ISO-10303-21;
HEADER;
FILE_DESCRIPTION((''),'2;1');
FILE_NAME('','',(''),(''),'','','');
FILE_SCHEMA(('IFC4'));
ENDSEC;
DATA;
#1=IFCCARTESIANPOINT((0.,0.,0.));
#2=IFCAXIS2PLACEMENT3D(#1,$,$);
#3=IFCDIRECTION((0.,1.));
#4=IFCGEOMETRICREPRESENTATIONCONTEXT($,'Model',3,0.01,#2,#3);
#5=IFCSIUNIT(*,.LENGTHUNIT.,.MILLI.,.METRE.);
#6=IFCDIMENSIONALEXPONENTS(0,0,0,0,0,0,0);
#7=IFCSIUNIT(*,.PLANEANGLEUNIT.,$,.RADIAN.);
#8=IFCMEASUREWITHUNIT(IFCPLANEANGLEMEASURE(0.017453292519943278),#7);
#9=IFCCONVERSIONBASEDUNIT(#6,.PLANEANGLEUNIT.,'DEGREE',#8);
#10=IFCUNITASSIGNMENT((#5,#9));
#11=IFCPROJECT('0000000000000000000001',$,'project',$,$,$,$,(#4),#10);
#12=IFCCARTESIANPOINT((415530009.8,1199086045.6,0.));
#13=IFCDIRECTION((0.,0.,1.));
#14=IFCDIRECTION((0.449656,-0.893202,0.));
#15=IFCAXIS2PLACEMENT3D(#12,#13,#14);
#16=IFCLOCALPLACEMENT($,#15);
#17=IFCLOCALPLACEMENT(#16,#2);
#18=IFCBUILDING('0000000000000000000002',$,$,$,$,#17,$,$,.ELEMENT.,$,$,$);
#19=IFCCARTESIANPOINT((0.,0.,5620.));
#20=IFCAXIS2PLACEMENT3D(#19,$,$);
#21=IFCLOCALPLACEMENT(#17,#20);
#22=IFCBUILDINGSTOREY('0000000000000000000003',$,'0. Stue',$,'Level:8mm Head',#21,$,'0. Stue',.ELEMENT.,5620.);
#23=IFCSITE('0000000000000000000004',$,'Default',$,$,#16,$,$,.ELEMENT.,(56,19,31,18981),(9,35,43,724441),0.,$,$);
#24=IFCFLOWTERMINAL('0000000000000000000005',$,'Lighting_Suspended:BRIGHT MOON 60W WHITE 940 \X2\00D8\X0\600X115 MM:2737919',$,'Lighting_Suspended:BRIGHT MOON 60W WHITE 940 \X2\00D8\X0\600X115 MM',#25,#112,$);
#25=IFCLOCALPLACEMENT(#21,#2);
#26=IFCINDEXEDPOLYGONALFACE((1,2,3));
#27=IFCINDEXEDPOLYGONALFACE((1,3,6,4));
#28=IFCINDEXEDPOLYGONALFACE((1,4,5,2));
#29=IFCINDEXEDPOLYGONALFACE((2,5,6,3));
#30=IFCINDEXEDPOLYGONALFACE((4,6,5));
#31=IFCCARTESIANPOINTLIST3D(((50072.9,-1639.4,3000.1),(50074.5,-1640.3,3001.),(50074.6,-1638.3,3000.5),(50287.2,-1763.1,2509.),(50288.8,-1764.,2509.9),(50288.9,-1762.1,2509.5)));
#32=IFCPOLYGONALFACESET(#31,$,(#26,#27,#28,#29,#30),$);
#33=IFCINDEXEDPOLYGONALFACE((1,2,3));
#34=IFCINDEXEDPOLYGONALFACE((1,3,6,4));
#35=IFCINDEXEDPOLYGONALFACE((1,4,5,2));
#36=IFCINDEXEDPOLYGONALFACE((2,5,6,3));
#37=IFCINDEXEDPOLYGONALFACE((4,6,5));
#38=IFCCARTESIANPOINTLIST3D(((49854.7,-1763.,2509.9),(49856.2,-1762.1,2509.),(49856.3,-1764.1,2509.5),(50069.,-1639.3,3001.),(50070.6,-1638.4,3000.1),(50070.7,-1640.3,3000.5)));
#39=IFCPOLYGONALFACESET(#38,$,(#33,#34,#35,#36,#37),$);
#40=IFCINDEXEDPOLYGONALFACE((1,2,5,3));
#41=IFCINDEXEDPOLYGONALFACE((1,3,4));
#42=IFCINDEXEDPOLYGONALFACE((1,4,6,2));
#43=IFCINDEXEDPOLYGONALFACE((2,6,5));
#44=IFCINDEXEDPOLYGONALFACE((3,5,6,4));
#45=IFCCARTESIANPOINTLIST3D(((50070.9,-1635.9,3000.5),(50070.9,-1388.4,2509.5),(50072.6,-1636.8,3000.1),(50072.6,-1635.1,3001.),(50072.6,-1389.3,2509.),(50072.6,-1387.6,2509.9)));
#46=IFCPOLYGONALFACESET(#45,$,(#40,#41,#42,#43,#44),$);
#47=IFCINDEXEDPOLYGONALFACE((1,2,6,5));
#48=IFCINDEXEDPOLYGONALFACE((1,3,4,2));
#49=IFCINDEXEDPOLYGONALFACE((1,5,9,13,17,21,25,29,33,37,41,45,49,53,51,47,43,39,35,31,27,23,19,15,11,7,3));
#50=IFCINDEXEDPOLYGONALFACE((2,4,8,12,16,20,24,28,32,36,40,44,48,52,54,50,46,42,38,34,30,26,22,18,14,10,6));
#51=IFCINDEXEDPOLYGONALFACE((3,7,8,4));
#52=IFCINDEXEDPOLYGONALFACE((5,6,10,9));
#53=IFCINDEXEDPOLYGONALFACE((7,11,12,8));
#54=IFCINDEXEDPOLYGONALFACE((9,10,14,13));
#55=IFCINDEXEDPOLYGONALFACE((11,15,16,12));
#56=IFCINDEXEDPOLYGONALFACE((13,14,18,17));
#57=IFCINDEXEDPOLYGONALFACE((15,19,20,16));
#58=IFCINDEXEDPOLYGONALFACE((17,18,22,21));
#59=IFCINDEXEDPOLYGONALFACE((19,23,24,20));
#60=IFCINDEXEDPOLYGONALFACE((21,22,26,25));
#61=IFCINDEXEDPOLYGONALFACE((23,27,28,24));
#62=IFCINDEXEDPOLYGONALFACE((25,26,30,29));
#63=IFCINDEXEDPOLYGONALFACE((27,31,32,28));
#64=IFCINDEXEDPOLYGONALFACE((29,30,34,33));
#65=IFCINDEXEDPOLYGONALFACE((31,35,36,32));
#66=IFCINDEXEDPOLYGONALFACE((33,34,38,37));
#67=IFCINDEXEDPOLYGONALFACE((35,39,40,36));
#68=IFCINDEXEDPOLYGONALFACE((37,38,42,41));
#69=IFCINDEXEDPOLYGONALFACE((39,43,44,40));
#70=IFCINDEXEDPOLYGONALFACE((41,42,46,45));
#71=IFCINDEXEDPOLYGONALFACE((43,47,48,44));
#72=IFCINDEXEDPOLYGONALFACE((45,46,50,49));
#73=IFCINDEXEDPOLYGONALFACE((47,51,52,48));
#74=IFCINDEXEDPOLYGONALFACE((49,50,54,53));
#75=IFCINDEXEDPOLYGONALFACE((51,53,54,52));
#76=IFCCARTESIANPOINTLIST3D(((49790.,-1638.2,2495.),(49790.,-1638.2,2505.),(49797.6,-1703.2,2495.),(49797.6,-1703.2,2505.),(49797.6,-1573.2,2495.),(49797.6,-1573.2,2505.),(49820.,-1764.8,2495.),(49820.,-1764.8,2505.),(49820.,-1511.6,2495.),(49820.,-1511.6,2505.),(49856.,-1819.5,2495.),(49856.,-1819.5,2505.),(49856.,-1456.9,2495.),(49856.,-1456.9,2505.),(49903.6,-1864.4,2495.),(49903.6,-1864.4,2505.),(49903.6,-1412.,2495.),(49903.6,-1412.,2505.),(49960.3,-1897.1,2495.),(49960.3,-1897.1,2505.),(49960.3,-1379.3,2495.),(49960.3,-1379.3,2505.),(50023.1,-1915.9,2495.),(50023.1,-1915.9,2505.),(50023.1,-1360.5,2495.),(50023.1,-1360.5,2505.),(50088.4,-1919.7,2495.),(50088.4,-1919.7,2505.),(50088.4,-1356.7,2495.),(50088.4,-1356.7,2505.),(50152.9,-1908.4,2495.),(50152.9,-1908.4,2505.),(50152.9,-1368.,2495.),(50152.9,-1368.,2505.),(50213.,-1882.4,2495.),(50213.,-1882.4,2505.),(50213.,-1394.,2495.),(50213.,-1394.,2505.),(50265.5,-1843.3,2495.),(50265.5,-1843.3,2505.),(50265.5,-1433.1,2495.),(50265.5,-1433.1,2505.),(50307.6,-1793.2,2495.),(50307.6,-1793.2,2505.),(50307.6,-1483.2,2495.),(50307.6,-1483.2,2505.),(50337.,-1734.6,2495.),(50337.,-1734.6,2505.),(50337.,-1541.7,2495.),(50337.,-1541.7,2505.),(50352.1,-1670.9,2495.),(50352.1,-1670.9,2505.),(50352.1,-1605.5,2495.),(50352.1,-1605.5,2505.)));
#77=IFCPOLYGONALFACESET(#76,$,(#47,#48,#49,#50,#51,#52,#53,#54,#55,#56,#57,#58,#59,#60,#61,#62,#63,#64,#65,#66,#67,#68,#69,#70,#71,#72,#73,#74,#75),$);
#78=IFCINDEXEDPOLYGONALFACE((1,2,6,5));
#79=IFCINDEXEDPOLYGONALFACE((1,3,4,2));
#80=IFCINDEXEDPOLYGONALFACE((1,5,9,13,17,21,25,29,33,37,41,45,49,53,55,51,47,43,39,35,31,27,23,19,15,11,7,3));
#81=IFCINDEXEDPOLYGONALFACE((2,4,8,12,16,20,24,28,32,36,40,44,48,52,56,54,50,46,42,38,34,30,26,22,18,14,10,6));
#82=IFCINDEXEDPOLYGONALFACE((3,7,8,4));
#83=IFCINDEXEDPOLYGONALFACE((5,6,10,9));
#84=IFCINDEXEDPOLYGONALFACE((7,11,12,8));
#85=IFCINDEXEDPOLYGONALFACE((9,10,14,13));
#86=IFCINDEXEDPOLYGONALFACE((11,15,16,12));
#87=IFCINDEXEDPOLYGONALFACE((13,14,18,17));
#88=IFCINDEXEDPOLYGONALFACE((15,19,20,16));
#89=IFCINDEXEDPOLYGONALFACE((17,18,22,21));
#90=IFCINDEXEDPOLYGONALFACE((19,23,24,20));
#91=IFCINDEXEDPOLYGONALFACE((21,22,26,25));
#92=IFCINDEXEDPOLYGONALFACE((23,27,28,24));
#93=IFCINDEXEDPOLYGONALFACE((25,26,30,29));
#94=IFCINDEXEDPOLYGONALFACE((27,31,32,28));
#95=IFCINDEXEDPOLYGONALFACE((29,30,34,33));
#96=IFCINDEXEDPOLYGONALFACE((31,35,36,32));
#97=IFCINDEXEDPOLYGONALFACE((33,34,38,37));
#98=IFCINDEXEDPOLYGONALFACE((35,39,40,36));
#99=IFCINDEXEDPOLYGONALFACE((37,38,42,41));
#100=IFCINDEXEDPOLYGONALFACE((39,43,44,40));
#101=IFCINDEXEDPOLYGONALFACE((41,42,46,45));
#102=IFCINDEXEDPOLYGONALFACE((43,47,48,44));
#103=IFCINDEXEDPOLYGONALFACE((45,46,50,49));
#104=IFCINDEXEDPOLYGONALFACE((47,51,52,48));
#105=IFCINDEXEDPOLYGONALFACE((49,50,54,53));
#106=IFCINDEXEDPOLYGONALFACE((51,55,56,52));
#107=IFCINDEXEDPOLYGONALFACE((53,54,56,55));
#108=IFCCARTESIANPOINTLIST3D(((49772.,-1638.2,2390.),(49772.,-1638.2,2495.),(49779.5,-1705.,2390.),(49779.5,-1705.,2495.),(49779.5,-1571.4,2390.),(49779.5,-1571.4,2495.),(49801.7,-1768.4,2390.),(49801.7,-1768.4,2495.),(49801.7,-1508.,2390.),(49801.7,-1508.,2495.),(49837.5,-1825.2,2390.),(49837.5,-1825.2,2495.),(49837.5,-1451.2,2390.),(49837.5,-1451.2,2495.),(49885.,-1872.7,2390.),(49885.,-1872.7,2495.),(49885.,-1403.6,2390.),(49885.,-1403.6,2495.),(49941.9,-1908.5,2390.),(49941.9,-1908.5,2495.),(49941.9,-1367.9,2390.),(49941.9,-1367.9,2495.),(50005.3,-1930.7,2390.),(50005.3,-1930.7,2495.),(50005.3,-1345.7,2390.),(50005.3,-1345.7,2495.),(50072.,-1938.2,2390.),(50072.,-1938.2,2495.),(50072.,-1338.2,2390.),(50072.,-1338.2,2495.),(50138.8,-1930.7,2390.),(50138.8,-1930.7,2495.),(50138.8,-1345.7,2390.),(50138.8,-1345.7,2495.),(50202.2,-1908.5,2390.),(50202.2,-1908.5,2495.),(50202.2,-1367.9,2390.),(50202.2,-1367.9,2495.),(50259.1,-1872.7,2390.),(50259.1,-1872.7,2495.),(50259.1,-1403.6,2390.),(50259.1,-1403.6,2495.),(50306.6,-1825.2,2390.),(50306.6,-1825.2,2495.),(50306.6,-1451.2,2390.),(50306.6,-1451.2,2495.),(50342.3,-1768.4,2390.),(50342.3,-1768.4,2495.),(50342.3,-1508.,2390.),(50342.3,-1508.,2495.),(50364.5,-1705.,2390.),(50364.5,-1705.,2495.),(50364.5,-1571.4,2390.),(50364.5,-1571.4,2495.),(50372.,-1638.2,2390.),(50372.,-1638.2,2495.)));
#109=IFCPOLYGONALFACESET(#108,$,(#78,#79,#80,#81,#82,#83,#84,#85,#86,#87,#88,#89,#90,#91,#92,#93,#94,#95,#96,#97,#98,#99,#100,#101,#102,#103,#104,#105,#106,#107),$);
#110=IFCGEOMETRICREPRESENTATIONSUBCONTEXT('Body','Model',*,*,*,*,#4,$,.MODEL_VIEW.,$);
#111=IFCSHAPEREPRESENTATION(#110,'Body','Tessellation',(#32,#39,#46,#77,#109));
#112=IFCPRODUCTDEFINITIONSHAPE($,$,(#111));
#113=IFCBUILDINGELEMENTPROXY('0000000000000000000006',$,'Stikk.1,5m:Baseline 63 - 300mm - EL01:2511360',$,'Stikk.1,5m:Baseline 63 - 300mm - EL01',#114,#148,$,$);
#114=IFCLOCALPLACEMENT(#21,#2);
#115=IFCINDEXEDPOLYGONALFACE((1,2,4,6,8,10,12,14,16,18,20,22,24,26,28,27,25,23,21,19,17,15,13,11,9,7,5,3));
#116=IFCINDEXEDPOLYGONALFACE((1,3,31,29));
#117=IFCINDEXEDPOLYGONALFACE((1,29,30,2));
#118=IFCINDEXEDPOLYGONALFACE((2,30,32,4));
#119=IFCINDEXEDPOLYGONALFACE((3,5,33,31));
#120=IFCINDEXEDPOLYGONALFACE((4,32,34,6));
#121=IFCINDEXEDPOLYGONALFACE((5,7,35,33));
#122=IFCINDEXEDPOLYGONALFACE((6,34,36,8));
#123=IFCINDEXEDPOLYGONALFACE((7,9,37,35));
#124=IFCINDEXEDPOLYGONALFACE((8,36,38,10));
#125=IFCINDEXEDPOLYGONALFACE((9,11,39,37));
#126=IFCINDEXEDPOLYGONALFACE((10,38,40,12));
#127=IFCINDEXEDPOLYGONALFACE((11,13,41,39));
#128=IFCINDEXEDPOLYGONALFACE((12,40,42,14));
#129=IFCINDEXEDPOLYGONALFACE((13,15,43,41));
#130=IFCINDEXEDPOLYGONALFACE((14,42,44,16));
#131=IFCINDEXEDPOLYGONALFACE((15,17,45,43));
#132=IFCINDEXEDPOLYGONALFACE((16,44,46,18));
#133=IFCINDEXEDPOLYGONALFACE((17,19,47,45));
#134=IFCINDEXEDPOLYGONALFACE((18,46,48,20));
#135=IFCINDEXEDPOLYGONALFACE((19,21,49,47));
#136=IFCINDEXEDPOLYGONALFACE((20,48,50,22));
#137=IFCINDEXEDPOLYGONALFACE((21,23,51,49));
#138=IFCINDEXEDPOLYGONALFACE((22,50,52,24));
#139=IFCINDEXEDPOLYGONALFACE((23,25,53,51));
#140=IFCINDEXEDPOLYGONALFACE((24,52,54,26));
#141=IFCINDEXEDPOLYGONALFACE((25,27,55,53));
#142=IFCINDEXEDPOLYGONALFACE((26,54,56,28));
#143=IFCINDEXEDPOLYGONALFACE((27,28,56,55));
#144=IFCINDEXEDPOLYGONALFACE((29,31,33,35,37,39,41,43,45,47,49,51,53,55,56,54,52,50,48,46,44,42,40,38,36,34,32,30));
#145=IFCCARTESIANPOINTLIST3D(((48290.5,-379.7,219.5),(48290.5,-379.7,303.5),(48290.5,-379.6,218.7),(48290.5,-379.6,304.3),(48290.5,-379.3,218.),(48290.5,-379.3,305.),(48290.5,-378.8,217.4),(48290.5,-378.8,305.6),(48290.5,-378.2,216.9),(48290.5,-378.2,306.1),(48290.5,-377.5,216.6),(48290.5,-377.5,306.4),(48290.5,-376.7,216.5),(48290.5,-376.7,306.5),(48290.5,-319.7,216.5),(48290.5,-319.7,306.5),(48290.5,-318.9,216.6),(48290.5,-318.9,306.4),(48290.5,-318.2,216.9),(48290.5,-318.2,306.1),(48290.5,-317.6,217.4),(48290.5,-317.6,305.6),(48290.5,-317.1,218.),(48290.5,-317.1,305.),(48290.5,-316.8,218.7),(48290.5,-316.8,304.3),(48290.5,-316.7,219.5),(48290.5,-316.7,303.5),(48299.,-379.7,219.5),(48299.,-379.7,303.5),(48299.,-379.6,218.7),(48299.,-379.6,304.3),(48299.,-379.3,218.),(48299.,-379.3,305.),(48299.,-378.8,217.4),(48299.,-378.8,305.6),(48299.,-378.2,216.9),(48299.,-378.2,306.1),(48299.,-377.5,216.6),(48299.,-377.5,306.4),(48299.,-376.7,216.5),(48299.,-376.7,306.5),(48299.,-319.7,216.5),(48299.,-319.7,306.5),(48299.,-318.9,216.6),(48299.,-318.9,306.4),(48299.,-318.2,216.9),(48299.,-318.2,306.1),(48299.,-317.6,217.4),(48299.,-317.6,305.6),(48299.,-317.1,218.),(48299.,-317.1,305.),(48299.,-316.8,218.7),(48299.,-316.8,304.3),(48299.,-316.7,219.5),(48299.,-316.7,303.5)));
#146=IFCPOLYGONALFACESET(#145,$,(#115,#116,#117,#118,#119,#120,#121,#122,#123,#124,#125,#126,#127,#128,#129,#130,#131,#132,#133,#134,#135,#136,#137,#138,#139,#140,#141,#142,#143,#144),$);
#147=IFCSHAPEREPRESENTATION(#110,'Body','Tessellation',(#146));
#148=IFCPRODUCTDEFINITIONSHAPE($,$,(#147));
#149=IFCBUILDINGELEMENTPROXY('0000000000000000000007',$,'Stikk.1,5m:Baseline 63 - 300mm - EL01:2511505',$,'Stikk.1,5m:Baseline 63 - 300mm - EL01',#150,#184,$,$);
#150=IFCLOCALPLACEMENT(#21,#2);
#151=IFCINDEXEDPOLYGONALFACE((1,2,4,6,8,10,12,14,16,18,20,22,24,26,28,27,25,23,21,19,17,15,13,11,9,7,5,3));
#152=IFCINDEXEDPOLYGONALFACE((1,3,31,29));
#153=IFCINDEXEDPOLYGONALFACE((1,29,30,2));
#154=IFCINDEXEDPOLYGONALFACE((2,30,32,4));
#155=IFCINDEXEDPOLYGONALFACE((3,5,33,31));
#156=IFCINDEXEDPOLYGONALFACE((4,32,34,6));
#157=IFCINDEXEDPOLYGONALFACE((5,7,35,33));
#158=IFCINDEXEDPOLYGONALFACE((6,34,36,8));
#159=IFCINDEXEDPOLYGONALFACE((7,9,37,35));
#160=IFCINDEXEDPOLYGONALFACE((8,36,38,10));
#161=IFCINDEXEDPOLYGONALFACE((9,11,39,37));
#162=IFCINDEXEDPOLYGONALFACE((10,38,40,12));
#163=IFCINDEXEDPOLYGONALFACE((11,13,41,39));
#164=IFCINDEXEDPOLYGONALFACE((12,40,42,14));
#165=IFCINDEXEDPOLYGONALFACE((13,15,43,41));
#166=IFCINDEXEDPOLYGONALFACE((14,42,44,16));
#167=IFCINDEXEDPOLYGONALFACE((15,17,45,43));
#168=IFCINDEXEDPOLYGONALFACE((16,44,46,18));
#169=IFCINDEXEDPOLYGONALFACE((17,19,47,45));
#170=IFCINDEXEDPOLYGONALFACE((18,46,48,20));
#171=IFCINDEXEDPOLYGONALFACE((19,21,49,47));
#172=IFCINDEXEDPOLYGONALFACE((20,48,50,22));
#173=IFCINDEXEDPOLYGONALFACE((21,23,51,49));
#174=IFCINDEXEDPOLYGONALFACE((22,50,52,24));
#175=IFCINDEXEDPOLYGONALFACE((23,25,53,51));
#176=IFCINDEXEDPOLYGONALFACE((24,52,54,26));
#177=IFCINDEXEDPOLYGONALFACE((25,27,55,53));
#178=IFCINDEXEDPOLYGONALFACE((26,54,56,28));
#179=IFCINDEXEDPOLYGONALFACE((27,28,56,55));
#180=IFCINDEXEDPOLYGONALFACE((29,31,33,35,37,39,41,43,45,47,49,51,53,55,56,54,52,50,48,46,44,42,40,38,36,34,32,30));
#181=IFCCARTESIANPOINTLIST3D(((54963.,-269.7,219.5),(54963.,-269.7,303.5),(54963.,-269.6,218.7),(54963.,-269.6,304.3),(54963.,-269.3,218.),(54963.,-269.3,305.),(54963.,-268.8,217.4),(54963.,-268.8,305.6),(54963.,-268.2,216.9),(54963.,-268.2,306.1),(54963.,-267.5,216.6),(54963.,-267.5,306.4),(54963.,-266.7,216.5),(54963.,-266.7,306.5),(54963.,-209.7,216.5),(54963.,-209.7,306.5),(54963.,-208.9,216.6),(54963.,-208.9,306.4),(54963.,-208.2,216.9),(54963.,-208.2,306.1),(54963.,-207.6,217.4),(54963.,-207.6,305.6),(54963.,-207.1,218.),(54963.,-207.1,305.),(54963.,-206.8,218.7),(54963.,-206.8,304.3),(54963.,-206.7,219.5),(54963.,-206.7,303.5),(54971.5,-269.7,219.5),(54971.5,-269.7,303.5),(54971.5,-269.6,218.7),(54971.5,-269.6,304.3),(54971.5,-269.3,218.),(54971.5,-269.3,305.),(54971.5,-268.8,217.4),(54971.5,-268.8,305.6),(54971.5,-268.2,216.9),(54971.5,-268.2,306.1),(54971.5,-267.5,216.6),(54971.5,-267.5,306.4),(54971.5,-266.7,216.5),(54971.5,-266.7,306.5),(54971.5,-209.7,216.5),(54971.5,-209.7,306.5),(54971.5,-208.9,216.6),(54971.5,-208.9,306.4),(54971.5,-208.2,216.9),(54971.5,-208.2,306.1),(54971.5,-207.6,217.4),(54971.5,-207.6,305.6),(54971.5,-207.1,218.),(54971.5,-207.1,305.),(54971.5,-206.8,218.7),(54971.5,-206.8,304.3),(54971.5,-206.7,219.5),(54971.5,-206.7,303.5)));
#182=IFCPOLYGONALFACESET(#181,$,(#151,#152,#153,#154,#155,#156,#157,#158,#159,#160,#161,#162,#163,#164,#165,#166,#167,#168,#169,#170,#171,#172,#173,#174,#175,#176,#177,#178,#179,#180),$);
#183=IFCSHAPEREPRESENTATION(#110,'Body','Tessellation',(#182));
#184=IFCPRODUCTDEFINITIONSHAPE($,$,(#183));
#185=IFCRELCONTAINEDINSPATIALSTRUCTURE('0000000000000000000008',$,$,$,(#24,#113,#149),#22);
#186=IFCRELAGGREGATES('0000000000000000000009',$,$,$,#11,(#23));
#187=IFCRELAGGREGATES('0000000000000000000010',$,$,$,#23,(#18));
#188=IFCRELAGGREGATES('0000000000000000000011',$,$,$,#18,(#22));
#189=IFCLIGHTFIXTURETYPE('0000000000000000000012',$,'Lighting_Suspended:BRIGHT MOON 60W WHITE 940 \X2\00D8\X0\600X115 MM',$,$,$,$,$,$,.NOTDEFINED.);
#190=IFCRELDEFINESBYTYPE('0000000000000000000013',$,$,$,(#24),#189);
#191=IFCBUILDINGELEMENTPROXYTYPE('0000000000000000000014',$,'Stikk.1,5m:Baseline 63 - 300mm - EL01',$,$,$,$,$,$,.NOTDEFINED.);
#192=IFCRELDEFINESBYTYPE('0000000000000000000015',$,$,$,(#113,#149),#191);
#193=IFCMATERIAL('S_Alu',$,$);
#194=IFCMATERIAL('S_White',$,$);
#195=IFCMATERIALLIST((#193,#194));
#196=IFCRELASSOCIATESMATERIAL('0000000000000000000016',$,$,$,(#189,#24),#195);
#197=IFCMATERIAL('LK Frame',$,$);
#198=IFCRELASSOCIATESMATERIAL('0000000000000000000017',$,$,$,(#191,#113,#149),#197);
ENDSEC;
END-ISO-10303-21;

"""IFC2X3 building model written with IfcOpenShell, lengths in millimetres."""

from ifc_helpers import new_model, entity, si_unit, converted_unit, direction, frame, frame_2d, origin, place, context, subcontext, project, spatial, polyline, circle_curve, parameter, trimmed, segment, composite_curve, circle, outline, extrude, source, transform, mapped, material, material_list, type_object, type_shapes, element, save


model = new_model("IFC2X3")

# Units and contexts
model_context = context("Model", 3, precision=0.01, world=origin(), true_north=direction((0.0, 1.0)))
body_context = subcontext(model_context, "Body", "Model", "MODEL_VIEW")
ifc_project = project(units=[si_unit("LENGTHUNIT", "METRE", prefix="MILLI"), converted_unit("PLANEANGLEUNIT", "DEGREE", entity("IfcPlaneAngleMeasure", 0.017453292519943278), si_unit("PLANEANGLEUNIT", "RADIAN"), dimensions=[0, 0, 0, 0, 0, 0, 0])], contexts=[model_context])

# Site, building, storey
site_placement = place(None, frame((415530009.8, 1199086045.6, 0.0), z_axis=(0.0, 0.0, 1.0), x_axis=(0.449656, -0.893202, 0.0)))
site = spatial("IfcSite", under=ifc_project, at=site_placement, Name="Default", CompositionType="ELEMENT", RefLatitude=(56, 19, 31, 18981), RefLongitude=(9, 35, 43, 724441), RefElevation=0.0)
building_placement = place(site_placement, origin())
building = spatial("IfcBuilding", under=site, at=building_placement, CompositionType="ELEMENT")
storey_placement = place(building_placement, frame((0.0, 0.0, 5620.0)))
storey = spatial("IfcBuildingStorey", under=building, at=storey_placement, Name="0. Stue", ObjectType="Level:8mm Head", LongName="0. Stue", CompositionType="ELEMENT", Elevation=5620.0)

# Flow terminal
ifc_material_1 = material(Name="S_White")
ifc_material_2 = material(Name="S_Alu")
ifc_material_list = material_list([ifc_material_2, ifc_material_1])
light_fixture_type_1 = type_object("IfcLightFixtureType", Name="Lighting_Suspended:BRIGHT MOON 60W WHITE 940 Ø600X115 MM", PredefinedType="NOTDEFINED", material=ifc_material_list)
shared_shape_1 = source(origin(), body_context, "Body", "SweptSolid", [
    extrude(outline(polyline([(-1.0, -0.6), (1.0, -0.6), (0.0, 1.2), (-1.0, -0.6)])), frame((-216.3, 124.9, -495.5), z_axis=(0.389771, -0.225034, 0.892994), x_axis=(-0.773355, 0.446497, 0.450069)), (0.0, 0.0, 1.0), 549.9),
    extrude(outline(polyline([(-1.0, -0.6), (1.0, -0.6), (0.0, 1.2), (-1.0, -0.6)])), frame((216.3, 124.9, -495.5), z_axis=(-0.389771, -0.225034, 0.892994), x_axis=(0.773355, 0.446497, 0.450069)), (0.0, 0.0, 1.0), 549.9),
    extrude(outline(polyline([(-1.0, -0.6), (1.0, -0.6), (0.0, 1.2), (-1.0, -0.6)])), frame((0.0, -249.7, -495.5), z_axis=(0.0, 0.450069, 0.892994), x_axis=(0.0, -0.892994, 0.450069)), (0.0, 0.0, 1.0), 549.9),
    extrude(circle(Radius=282.0, at=frame_2d((0.0, 0.0), x_axis=(1.0, 0.0))), frame((0.0, 0.0, -510.0)), (0.0, 0.0, 1.0), 10.0),
    extrude(circle(Radius=300.0, at=frame_2d((0.0, 0.0), x_axis=(1.0, 0.0))), frame((0.0, 0.0, -615.0)), (0.0, 0.0, 1.0), 105.0),
])
type_shapes(light_fixture_type_1, [shared_shape_1])
for number, where, z_axis, x_axis, name in (
    (1, (50072.0, -1638.2, 3005.0), (0.0, 0.0, 1.0), (-1.0, 0.0, 0.0), "Lighting_Suspended:BRIGHT MOON 60W WHITE 940 Ø600X115 MM:2737919"),
):
    element("IfcFlowTerminal", number, at=place(storey_placement, frame(where, z_axis=z_axis, x_axis=x_axis)), inside=storey, type_object=light_fixture_type_1, material=ifc_material_list, Name=name, ObjectType="Lighting_Suspended:BRIGHT MOON 60W WHITE 940 Ø600X115 MM", context=body_context, shape_type="MappedRepresentation", body=[
        mapped(shared_shape_1, transform((0.0, 0.0, 0.0), scale=1.0)),
    ])

# Building element proxies
ifc_material_3 = material(Name="LK Frame")
building_element_proxy_type_1 = type_object("IfcBuildingElementProxyType", Name="Stikk.1,5m:Baseline 63 - 300mm - EL01", PredefinedType="NOTDEFINED", material=ifc_material_3)
shared_shape_2 = source(origin(), body_context, "Body", "SweptSolid", [
    extrude(outline(composite_curve([segment(polyline([(-42.0, -31.5), (42.0, -31.5)]), True, "CONTINUOUS"), segment(trimmed(circle_curve(frame_2d((42.0, -28.5), x_axis=(-1.0, 0.0)), 3.0), [parameter(90.0)], [parameter(180.0)], True, "PARAMETER"), True, "CONTINUOUS"), segment(polyline([(45.0, -28.5), (45.0, 28.5)]), True, "CONTINUOUS"), segment(trimmed(circle_curve(frame_2d((42.0, 28.5), x_axis=(-1.0, 0.0)), 3.0), [parameter(180.0)], [parameter(270.0)], True, "PARAMETER"), True, "CONTINUOUS"), segment(polyline([(42.0, 31.5), (-42.0, 31.5)]), True, "CONTINUOUS"), segment(trimmed(circle_curve(frame_2d((-42.0, 28.5), x_axis=(1.0, 0.0)), 3.0), [parameter(90.0)], [parameter(180.0)], True, "PARAMETER"), True, "CONTINUOUS"), segment(polyline([(-45.0, 28.5), (-45.0, -28.5)]), True, "CONTINUOUS"), segment(trimmed(circle_curve(frame_2d((-42.0, -28.5), x_axis=(1.0, 0.0)), 3.0), [parameter(180.0)], [parameter(270.0)], True, "PARAMETER"), True, "CONTINUOUS")], self_intersect=False)), frame((0.0, -38.5, 0.0), z_axis=(0.0, 0.0, 1.0), x_axis=(0.0, 1.0, 0.0)), (0.0, 0.0, 1.0), 8.5),
])
type_shapes(building_element_proxy_type_1, [shared_shape_2])
for number, where, z_axis, x_axis, name in (
    (2, (48290.5, -348.2, 300.0), (1.0, 0.0, 0.0), (0.0, 1.0, 0.0), "Stikk.1,5m:Baseline 63 - 300mm - EL01:2511360"),
    (3, (54971.5, -238.2, 300.0), (-1.0, 0.0, 0.0), (0.0, -1.0, 0.0), "Stikk.1,5m:Baseline 63 - 300mm - EL01:2511505"),
):
    element("IfcBuildingElementProxy", number, at=place(storey_placement, frame(where, z_axis=z_axis, x_axis=x_axis)), inside=storey, type_object=building_element_proxy_type_1, material=ifc_material_3, Name=name, ObjectType="Stikk.1,5m:Baseline 63 - 300mm - EL01", context=body_context, shape_type="MappedRepresentation", body=[
        mapped(shared_shape_2, transform((0.0, 0.0, 0.0), scale=1.0)),
    ])

save(model, "model.ifc")
